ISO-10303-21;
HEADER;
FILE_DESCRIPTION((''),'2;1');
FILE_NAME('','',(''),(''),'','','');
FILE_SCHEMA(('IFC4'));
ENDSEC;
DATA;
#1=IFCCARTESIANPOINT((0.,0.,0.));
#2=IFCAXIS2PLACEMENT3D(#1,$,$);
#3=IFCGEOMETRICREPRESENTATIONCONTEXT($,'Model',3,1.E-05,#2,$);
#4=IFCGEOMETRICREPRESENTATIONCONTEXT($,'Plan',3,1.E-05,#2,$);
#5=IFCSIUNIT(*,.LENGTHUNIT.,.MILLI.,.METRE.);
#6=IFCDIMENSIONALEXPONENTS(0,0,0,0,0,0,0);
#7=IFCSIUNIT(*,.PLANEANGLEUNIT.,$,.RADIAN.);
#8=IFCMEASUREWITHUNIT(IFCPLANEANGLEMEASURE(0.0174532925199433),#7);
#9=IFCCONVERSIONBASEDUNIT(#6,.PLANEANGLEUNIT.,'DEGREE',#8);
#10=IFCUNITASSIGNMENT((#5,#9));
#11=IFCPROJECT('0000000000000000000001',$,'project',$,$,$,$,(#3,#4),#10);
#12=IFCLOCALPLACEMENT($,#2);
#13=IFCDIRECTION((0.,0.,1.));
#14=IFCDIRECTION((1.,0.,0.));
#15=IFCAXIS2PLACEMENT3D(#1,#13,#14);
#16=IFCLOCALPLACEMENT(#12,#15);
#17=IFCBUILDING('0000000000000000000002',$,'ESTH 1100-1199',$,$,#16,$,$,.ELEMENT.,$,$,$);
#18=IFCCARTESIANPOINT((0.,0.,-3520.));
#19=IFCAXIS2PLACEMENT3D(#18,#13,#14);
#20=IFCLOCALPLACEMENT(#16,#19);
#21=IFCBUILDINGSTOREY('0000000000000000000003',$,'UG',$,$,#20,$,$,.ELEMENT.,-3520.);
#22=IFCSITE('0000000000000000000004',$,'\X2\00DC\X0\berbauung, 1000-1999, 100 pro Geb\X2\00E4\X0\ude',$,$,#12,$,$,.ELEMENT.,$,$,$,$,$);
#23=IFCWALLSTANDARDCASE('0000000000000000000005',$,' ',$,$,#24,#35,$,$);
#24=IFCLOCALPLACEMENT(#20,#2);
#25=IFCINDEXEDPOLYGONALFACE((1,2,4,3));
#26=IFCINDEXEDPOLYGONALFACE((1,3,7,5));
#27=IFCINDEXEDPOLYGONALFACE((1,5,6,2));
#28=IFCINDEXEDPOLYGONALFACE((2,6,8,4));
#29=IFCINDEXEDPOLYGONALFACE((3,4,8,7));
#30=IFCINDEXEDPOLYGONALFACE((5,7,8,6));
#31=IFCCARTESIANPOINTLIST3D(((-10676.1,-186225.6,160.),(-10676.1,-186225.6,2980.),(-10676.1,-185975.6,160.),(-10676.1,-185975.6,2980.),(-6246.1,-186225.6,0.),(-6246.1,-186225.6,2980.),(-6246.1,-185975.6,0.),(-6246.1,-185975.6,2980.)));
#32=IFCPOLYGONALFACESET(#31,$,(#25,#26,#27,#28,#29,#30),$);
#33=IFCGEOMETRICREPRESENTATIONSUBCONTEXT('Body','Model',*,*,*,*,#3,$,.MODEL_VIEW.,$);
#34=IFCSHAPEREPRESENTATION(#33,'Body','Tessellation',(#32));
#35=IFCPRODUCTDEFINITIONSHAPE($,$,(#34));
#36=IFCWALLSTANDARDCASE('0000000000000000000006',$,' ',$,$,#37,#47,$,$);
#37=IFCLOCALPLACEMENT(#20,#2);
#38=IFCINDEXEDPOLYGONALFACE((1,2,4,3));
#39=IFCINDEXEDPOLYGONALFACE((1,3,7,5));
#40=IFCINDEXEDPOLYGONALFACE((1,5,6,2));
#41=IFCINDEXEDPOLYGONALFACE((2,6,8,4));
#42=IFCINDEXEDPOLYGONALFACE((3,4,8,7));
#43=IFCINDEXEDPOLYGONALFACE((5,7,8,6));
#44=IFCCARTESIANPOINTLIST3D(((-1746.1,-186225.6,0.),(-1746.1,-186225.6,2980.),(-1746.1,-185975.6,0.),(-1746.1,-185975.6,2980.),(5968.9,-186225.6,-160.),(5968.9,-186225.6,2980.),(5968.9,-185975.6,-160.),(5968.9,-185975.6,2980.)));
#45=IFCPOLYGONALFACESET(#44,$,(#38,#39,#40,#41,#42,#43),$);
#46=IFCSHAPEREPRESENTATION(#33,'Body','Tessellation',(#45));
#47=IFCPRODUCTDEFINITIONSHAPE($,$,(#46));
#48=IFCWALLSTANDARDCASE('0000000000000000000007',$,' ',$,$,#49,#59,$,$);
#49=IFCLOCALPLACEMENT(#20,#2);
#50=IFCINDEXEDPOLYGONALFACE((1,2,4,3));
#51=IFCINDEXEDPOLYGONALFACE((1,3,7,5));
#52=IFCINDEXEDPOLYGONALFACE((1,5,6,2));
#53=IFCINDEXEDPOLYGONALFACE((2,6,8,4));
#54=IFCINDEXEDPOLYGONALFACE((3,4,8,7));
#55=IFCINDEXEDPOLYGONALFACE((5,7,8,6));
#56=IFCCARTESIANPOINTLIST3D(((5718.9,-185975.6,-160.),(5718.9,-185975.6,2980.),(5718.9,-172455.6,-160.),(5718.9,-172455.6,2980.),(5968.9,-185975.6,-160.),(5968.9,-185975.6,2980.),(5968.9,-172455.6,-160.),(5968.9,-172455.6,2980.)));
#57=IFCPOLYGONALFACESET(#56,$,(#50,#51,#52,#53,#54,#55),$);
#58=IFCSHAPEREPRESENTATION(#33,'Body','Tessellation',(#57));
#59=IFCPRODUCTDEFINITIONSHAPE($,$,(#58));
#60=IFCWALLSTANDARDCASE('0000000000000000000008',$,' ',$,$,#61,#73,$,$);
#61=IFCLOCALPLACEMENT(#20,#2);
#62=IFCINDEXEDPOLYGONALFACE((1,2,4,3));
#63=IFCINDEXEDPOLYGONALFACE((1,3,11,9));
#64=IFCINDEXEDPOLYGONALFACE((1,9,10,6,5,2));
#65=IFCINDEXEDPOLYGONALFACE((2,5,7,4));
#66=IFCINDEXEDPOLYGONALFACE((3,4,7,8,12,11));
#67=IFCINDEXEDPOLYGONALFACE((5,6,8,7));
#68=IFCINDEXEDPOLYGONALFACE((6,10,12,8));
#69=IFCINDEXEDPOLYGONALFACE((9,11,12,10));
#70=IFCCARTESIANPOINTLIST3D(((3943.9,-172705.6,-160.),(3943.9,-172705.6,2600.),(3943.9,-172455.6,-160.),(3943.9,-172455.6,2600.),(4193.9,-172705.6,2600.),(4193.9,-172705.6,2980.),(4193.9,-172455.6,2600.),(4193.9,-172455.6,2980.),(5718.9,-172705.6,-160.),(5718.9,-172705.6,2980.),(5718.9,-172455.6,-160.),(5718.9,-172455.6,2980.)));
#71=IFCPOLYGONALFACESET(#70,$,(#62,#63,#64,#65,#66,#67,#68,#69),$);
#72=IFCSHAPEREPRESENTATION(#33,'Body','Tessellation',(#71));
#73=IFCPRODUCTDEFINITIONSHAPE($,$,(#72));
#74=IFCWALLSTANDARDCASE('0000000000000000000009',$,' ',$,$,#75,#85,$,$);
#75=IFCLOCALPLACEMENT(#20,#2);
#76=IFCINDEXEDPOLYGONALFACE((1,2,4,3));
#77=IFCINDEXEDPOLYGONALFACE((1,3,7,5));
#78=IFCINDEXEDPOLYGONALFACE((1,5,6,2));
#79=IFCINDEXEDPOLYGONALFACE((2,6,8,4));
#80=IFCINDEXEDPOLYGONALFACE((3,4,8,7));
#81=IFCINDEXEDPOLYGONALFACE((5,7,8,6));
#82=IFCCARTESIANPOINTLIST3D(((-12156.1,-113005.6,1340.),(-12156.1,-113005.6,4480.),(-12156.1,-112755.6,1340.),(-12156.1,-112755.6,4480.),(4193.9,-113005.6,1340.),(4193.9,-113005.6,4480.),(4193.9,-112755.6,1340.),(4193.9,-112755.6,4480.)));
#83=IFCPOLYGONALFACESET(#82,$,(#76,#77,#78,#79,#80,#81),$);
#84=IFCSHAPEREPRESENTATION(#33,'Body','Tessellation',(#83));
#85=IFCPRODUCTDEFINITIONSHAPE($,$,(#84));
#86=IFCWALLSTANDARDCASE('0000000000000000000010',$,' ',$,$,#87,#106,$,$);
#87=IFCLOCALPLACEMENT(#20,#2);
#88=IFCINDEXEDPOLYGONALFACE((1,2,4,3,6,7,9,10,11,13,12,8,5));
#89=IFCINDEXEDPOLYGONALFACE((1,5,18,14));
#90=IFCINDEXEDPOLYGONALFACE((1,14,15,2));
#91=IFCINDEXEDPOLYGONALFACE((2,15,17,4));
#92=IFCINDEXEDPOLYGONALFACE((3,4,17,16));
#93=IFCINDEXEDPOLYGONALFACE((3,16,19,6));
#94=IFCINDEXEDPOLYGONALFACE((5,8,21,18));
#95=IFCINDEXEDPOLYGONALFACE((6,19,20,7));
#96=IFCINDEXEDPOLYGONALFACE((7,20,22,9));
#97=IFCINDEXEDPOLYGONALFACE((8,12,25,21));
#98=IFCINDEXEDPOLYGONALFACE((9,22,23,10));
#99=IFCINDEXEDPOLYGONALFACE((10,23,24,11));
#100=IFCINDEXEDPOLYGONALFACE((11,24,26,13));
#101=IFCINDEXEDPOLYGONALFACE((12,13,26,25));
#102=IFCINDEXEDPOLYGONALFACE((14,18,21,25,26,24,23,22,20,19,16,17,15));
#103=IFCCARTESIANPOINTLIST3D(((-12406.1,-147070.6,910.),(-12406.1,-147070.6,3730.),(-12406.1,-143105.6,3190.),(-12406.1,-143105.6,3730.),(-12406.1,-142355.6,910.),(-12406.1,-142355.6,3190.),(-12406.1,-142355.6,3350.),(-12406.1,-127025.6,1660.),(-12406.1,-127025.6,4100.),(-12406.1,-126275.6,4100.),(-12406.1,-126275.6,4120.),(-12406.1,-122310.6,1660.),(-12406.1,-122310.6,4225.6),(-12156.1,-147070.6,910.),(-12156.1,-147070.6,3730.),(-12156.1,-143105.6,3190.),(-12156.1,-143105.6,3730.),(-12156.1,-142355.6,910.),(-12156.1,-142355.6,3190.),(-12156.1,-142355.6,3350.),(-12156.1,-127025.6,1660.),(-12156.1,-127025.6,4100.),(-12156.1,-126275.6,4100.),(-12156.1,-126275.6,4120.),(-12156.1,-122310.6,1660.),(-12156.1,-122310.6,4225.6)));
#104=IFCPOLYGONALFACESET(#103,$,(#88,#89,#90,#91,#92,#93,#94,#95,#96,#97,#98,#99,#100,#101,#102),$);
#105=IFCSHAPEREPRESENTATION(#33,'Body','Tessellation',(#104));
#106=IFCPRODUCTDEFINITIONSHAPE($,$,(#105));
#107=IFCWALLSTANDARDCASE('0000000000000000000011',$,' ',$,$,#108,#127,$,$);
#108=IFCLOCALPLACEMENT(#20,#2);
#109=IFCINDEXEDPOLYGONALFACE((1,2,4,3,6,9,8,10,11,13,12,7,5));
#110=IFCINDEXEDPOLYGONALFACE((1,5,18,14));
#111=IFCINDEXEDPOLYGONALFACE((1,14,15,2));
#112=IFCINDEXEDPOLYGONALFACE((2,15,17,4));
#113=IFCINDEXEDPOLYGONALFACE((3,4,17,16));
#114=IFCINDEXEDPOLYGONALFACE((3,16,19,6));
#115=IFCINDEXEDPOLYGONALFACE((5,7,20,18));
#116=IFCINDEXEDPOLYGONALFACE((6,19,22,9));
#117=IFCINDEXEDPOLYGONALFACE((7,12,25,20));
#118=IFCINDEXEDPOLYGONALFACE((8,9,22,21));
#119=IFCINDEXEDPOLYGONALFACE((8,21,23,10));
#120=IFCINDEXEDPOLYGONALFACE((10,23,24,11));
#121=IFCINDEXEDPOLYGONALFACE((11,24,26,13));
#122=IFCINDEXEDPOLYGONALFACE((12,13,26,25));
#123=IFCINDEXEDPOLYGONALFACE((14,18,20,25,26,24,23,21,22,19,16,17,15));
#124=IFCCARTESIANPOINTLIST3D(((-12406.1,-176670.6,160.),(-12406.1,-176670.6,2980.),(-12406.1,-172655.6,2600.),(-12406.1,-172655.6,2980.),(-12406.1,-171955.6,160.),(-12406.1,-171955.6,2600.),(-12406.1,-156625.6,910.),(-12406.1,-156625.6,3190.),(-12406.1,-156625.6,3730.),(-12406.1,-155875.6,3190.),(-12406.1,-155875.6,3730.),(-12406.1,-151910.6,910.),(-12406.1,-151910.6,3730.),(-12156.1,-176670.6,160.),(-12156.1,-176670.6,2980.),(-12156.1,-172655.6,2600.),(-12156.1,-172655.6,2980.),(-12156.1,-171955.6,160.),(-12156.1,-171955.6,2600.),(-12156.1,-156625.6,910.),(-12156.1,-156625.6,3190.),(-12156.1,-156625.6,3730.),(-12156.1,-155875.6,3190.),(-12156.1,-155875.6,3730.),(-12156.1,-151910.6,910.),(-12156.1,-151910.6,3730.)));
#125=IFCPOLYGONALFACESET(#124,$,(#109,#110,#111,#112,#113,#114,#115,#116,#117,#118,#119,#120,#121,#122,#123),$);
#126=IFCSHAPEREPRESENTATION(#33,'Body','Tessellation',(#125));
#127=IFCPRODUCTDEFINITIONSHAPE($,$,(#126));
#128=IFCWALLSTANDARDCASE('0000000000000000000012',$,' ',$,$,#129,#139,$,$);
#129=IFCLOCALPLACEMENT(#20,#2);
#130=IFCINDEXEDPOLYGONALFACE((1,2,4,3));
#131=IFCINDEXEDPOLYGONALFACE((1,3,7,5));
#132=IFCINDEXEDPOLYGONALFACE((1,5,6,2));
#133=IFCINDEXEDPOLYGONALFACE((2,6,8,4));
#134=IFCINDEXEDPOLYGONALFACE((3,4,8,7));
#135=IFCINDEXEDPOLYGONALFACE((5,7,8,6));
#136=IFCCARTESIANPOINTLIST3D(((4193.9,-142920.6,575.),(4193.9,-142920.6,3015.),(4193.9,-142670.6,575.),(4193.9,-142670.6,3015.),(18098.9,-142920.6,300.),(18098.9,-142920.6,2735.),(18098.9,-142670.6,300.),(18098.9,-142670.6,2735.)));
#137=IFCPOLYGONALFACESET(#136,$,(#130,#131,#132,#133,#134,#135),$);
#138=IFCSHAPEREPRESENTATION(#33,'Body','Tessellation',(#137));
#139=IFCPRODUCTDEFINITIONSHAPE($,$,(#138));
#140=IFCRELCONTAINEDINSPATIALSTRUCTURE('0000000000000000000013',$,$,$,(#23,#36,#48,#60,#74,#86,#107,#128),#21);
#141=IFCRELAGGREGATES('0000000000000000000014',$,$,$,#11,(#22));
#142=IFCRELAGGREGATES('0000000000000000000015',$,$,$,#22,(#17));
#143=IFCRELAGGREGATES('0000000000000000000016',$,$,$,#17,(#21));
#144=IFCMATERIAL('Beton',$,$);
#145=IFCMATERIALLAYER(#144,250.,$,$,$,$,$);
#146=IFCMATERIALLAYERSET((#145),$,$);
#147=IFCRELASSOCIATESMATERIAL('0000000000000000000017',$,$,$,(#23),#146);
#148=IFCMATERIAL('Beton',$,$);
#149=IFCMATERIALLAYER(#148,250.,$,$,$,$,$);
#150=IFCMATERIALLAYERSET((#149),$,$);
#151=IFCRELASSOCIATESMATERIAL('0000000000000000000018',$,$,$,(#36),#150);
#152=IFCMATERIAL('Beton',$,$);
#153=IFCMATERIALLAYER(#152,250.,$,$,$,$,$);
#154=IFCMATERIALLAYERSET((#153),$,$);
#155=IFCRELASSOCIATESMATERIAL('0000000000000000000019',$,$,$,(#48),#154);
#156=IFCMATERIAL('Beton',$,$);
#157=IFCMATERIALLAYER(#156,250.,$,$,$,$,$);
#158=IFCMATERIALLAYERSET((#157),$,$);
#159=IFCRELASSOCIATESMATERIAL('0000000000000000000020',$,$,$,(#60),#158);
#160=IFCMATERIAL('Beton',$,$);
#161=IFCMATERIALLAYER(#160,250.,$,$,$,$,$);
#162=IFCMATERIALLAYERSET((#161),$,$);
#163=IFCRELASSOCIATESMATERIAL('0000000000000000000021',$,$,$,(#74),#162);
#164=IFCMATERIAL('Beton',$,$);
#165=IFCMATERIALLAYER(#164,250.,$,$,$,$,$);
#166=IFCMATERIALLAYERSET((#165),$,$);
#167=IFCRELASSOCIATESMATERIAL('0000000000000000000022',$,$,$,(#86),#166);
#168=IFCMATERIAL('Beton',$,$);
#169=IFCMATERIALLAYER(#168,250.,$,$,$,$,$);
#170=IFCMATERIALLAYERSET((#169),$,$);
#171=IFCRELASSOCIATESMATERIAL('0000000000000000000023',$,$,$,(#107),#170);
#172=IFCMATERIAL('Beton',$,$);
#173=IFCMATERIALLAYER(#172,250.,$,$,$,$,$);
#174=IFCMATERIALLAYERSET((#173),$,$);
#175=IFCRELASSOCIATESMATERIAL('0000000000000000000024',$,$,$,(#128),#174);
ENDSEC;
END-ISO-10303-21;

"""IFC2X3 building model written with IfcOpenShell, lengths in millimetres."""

from ifc_helpers import new_model, entity, si_unit, converted_unit, frame, frame_2d, origin, origin_with_axes, place, context, subcontext, project, spatial, polyline, rectangle, extrude, clip, halfspace, bounded_halfspace, material, layer, layer_set, layer_usage, element, save


model = new_model("IFC2X3")

# Units and contexts
model_context = context("Model", 3, precision=1e-05, world=origin())
plan_context = context("Plan", 3, precision=1e-05, world=origin())
body_context = subcontext(model_context, "Body", "Model", "MODEL_VIEW")
ifc_project = project(units=[si_unit("LENGTHUNIT", "METRE", prefix="MILLI"), converted_unit("PLANEANGLEUNIT", "DEGREE", entity("IfcPlaneAngleMeasure", 0.0174532925199433), si_unit("PLANEANGLEUNIT", "RADIAN"), dimensions=[0, 0, 0, 0, 0, 0, 0])], contexts=[model_context, plan_context])

# Site, building, storey
site_placement = place(None, origin())
site = spatial("IfcSite", under=ifc_project, at=site_placement, Name="Überbauung, 1000-1999, 100 pro Gebäude", CompositionType="ELEMENT")
building_placement = place(site_placement, origin_with_axes())
building = spatial("IfcBuilding", under=site, at=building_placement, Name="ESTH 1100-1199", CompositionType="ELEMENT")
storey_placement = place(building_placement, frame((0.0, 0.0, -3520.0), z_axis=(0.0, 0.0, 1.0), x_axis=(1.0, 0.0, 0.0)))
storey = spatial("IfcBuildingStorey", under=building, at=storey_placement, Name="UG", CompositionType="ELEMENT", Elevation=-3520.0)

# Walls
ifc_material_1 = material(Name="Beton")
ifc_layer_1 = layer(ifc_material_1, 250.0)
ifc_layer_set_1 = layer_set([ifc_layer_1])
ifc_layer_usage_1 = layer_usage(ifc_layer_set_1, "AXIS2", "POSITIVE", 0.0)
wall_1_placement = place(storey_placement, frame((-10676.1, -186225.6, 0.0), z_axis=(0.0, 0.0, 1.0), x_axis=(1.0, 0.0, 0.0)))
element("IfcWallStandardCase", 1, at=wall_1_placement, inside=storey, material=ifc_layer_usage_1, Name=" ", context=body_context, shape_type="Clipping", body=[
    clip(extrude(rectangle(XDim=4430.0, YDim=250.0, at=frame_2d((2215.0, 125.0), x_axis=(1.0, 0.0))), origin_with_axes(), (0.0, 0.0, 1.0), 2980.0), halfspace(frame((0.0, 250.0, 160.0), z_axis=(0.036094, 0.0, 0.999348), x_axis=(0.0, -1.0, 0.0)), True)),
])
ifc_material_2 = material(Name="Beton")
ifc_layer_2 = layer(ifc_material_2, 250.0)
ifc_layer_set_2 = layer_set([ifc_layer_2])
ifc_layer_usage_2 = layer_usage(ifc_layer_set_2, "AXIS2", "POSITIVE", 0.0)
wall_2_placement = place(storey_placement, frame((-1746.1, -186225.6, -160.0), z_axis=(0.0, 0.0, 1.0), x_axis=(1.0, 0.0, 0.0)))
element("IfcWallStandardCase", 2, at=wall_2_placement, inside=storey, material=ifc_layer_usage_2, Name=" ", context=body_context, shape_type="Clipping", body=[
    clip(extrude(rectangle(XDim=7715.0, YDim=250.0, at=frame_2d((3857.5, 125.0), x_axis=(1.0, 0.0))), origin_with_axes(), (0.0, 0.0, 1.0), 3140.0), halfspace(frame((0.0, 250.0, 160.0), z_axis=(0.020734, 0.0, 0.999785), x_axis=(0.0, -1.0, 0.0)), True)),
])
ifc_material_3 = material(Name="Beton")
ifc_layer_3 = layer(ifc_material_3, 250.0)
ifc_layer_set_3 = layer_set([ifc_layer_3])
ifc_layer_usage_3 = layer_usage(ifc_layer_set_3, "AXIS2", "POSITIVE", 0.0)
wall_3_placement = place(storey_placement, frame((5968.9, -185975.6, -160.0), z_axis=(0.0, 0.0, 1.0), x_axis=(0.0, 1.0, 0.0)))
element("IfcWallStandardCase", 3, at=wall_3_placement, inside=storey, material=ifc_layer_usage_3, Name=" ", context=body_context, shape_type="SweptSolid", body=[
    extrude(rectangle(XDim=13520.0, YDim=250.0, at=frame_2d((6760.0, 125.0), x_axis=(1.0, 0.0))), origin_with_axes(), (0.0, 0.0, 1.0), 3140.0),
])
ifc_material_4 = material(Name="Beton")
ifc_layer_4 = layer(ifc_material_4, 250.0)
ifc_layer_set_4 = layer_set([ifc_layer_4])
ifc_layer_usage_4 = layer_usage(ifc_layer_set_4, "AXIS2", "POSITIVE", 0.0)
wall_4_placement = place(storey_placement, frame((5718.9, -172455.6, -160.0), z_axis=(0.0, 0.0, 1.0), x_axis=(-1.0, 0.0, 0.0)))
element("IfcWallStandardCase", 4, at=wall_4_placement, inside=storey, material=ifc_layer_usage_4, Name=" ", context=body_context, shape_type="Clipping", body=[
    clip(clip(extrude(rectangle(XDim=1775.0, YDim=250.0, at=frame_2d((887.5, 125.0), x_axis=(1.0, 0.0))), origin_with_axes(), (0.0, 0.0, 1.0), 3140.0), bounded_halfspace(frame((1525.0, 250.0, 3140.0), z_axis=(0.0, 0.0, -1.0), x_axis=(-1.0, 0.0, 0.0)), True, origin(), polyline([(1525.0, 250.0), (0.0, 250.0), (0.0, 0.0), (1525.0, 0.0), (1525.0, 250.0)]))), bounded_halfspace(frame((1775.0, 0.0, 2760.0), z_axis=(0.0, 0.0, -1.0), x_axis=(0.0, 1.0, 0.0)), True, origin(), polyline([(1775.0, 0.0), (1775.0, 250.0), (1525.0, 250.0), (1525.0, 0.0), (1775.0, 0.0)]))),
])
ifc_material_5 = material(Name="Beton")
ifc_layer_5 = layer(ifc_material_5, 250.0)
ifc_layer_set_5 = layer_set([ifc_layer_5])
ifc_layer_usage_5 = layer_usage(ifc_layer_set_5, "AXIS2", "POSITIVE", 0.0)
wall_5_placement = place(storey_placement, frame((4193.9, -112755.6, 1340.0), z_axis=(0.0, 0.0, 1.0), x_axis=(-1.0, 0.0, 0.0)))
element("IfcWallStandardCase", 5, at=wall_5_placement, inside=storey, material=ifc_layer_usage_5, Name=" ", context=body_context, shape_type="SweptSolid", body=[
    extrude(rectangle(XDim=16350.0, YDim=250.0, at=frame_2d((8175.0, 125.0), x_axis=(1.0, 0.0))), origin_with_axes(), (0.0, 0.0, 1.0), 3140.0),
])
ifc_material_6 = material(Name="Beton")
ifc_layer_6 = layer(ifc_material_6, 250.0)
ifc_layer_set_6 = layer_set([ifc_layer_6])
ifc_layer_usage_6 = layer_usage(ifc_layer_set_6, "AXIS2", "POSITIVE", 0.0)
wall_6_placement = place(storey_placement, frame((-12406.1, -122310.6, 910.0), z_axis=(0.0, 0.0, 1.0), x_axis=(0.0, -1.0, 0.0)))
element("IfcWallStandardCase", 6, at=wall_6_placement, inside=storey, material=ifc_layer_usage_6, Name=" ", context=body_context, shape_type="Clipping", body=[
    clip(clip(clip(clip(clip(clip(clip(clip(extrude(rectangle(XDim=24760.0, YDim=250.0, at=frame_2d((12380.0, 125.0), x_axis=(1.0, 0.0))), origin_with_axes(), (0.0, 0.0, 1.0), 3315.6), bounded_halfspace(frame((20045.0, 250.0, 0.0), z_axis=(0.0, 0.0, 1.0), x_axis=(0.0, -1.0, 0.0)), True, origin(), polyline([(20045.0, 250.0), (20045.0, 0.0), (24760.0, 0.0), (24760.0, 250.0), (20045.0, 250.0)]))), bounded_halfspace(frame((20795.0, 0.0, 2820.0), z_axis=(0.0, 0.0, -1.0), x_axis=(1.0, 0.0, 0.0)), True, origin(), polyline([(20795.0, 0.0), (24760.0, 0.0), (24760.0, 250.0), (20795.0, 250.0), (20795.0, 0.0)]))), bounded_halfspace(frame((20045.0, 0.0, 2280.0), z_axis=(0.0, 0.0, -1.0), x_axis=(1.0, 0.0, 0.0)), True, origin(), polyline([(20045.0, 0.0), (20795.0, 0.0), (20795.0, 250.0), (20045.0, 250.0), (20045.0, 0.0)]))), bounded_halfspace(frame((4715.0, 250.0, 750.0), z_axis=(0.048865, 0.0, 0.998805), x_axis=(0.0, -1.0, 0.0)), True, origin(), polyline([(4715.0, 250.0), (4715.0, 0.0), (20045.0, 0.0), (20045.0, 250.0), (4715.0, 250.0)]))), bounded_halfspace(frame((4715.0, 0.0, 3190.0), z_axis=(-0.048865, 0.0, -0.998805), x_axis=(0.998805, 0.0, -0.048865)), True, origin(), polyline([(4715.0, 0.0), (20045.0, 0.0), (20045.0, 250.0), (4715.0, 250.0), (4715.0, 0.0)]))), bounded_halfspace(frame((0.0, 250.0, 750.0), z_axis=(0.0, 0.0, 1.0), x_axis=(0.0, -1.0, 0.0)), True, origin(), polyline([(0.0, 250.0), (0.0, 0.0), (4715.0, 0.0), (4715.0, 250.0), (0.0, 250.0)]))), bounded_halfspace(frame((3965.0, 0.0, 3190.0), z_axis=(0.0, 0.0, -1.0), x_axis=(1.0, 0.0, 0.0)), True, origin(), polyline([(3965.0, 0.0), (4715.0, 0.0), (4715.0, 250.0), (3965.0, 250.0), (3965.0, 0.0)]))), bounded_halfspace(frame((3965.0, 250.0, 3210.0), z_axis=(-0.02662, 0.0, -0.999646), x_axis=(-0.999646, 0.0, 0.02662)), True, origin(), polyline([(3965.0, 250.0), (0.0, 250.0), (0.0, 0.0), (3965.0, 0.0), (3965.0, 250.0)]))),
])
ifc_material_7 = material(Name="Beton")
ifc_layer_7 = layer(ifc_material_7, 250.0)
ifc_layer_set_7 = layer_set([ifc_layer_7])
ifc_layer_usage_7 = layer_usage(ifc_layer_set_7, "AXIS2", "POSITIVE", 0.0)
wall_7_placement = place(storey_placement, frame((-12406.1, -151910.6, 160.0), z_axis=(0.0, 0.0, 1.0), x_axis=(0.0, -1.0, 0.0)))
element("IfcWallStandardCase", 7, at=wall_7_placement, inside=storey, material=ifc_layer_usage_7, Name=" ", context=body_context, shape_type="Clipping", body=[
    clip(clip(clip(clip(clip(clip(clip(clip(extrude(rectangle(XDim=24760.0, YDim=250.0, at=frame_2d((12380.0, 125.0), x_axis=(1.0, 0.0))), origin_with_axes(), (0.0, 0.0, 1.0), 3570.0), bounded_halfspace(frame((20045.0, 250.0, 0.0), z_axis=(0.0, 0.0, 1.0), x_axis=(0.0, -1.0, 0.0)), True, origin(), polyline([(20045.0, 250.0), (20045.0, 0.0), (24760.0, 0.0), (24760.0, 250.0), (20045.0, 250.0)]))), bounded_halfspace(frame((20745.0, 0.0, 2820.0), z_axis=(0.0, 0.0, -1.0), x_axis=(1.0, 0.0, 0.0)), True, origin(), polyline([(20745.0, 0.0), (24760.0, 0.0), (24760.0, 250.0), (20745.0, 250.0), (20745.0, 0.0)]))), bounded_halfspace(frame((20045.0, 0.0, 2440.0), z_axis=(0.0, 0.0, -1.0), x_axis=(1.0, 0.0, 0.0)), True, origin(), polyline([(20045.0, 0.0), (20745.0, 0.0), (20745.0, 250.0), (20045.0, 250.0), (20045.0, 0.0)]))), bounded_halfspace(frame((4715.0, 250.0, 750.0), z_axis=(0.048865, 0.0, 0.998805), x_axis=(0.0, -1.0, 0.0)), True, origin(), polyline([(4715.0, 250.0), (4715.0, 0.0), (20045.0, 0.0), (20045.0, 250.0), (4715.0, 250.0)]))), bounded_halfspace(frame((4715.0, 0.0, 3570.0), z_axis=(-0.073512, 0.0, -0.997294), x_axis=(0.997294, 0.0, -0.073512)), True, origin(), polyline([(4715.0, 0.0), (20045.0, 0.0), (20045.0, 250.0), (4715.0, 250.0), (4715.0, 0.0)]))), bounded_halfspace(frame((0.0, 250.0, 750.0), z_axis=(0.0, 0.0, 1.0), x_axis=(0.0, -1.0, 0.0)), True, origin(), polyline([(0.0, 250.0), (0.0, 0.0), (4715.0, 0.0), (4715.0, 250.0), (0.0, 250.0)]))), bounded_halfspace(frame((3965.0, 0.0, 3030.0), z_axis=(0.0, 0.0, -1.0), x_axis=(1.0, 0.0, 0.0)), True, origin(), polyline([(3965.0, 0.0), (4715.0, 0.0), (4715.0, 250.0), (3965.0, 250.0), (3965.0, 0.0)]))), bounded_halfspace(frame((0.0, 0.0, 3570.0), z_axis=(0.0, 0.0, -1.0), x_axis=(1.0, 0.0, 0.0)), True, origin(), polyline([(0.0, 0.0), (3965.0, 0.0), (3965.0, 250.0), (0.0, 250.0), (0.0, 0.0)]))),
])
ifc_material_8 = material(Name="Beton")
ifc_layer_8 = layer(ifc_material_8, 250.0)
ifc_layer_set_8 = layer_set([ifc_layer_8])
ifc_layer_usage_8 = layer_usage(ifc_layer_set_8, "AXIS2", "POSITIVE", 0.0)
wall_8_placement = place(storey_placement, frame((4193.9, -142920.6, 300.0), z_axis=(0.0, 0.0, 1.0), x_axis=(1.0, 0.0, 0.0)))
element("IfcWallStandardCase", 8, at=wall_8_placement, inside=storey, material=ifc_layer_usage_8, Name=" ", context=body_context, shape_type="Clipping", body=[
    clip(clip(extrude(rectangle(XDim=13905.0, YDim=250.0, at=frame_2d((6952.5, 125.0), x_axis=(1.0, 0.0))), origin_with_axes(), (0.0, 0.0, 1.0), 2715.0), halfspace(frame((0.0, 250.0, 275.0), z_axis=(0.019773, 0.0, 0.999804), x_axis=(0.0, -1.0, 0.0)), True)), halfspace(frame((0.0, 0.0, 2715.0), z_axis=(-0.020133, 0.0, -0.999797), x_axis=(0.999797, 0.0, -0.020133)), True)),
])

save(model, "model.ifc")
